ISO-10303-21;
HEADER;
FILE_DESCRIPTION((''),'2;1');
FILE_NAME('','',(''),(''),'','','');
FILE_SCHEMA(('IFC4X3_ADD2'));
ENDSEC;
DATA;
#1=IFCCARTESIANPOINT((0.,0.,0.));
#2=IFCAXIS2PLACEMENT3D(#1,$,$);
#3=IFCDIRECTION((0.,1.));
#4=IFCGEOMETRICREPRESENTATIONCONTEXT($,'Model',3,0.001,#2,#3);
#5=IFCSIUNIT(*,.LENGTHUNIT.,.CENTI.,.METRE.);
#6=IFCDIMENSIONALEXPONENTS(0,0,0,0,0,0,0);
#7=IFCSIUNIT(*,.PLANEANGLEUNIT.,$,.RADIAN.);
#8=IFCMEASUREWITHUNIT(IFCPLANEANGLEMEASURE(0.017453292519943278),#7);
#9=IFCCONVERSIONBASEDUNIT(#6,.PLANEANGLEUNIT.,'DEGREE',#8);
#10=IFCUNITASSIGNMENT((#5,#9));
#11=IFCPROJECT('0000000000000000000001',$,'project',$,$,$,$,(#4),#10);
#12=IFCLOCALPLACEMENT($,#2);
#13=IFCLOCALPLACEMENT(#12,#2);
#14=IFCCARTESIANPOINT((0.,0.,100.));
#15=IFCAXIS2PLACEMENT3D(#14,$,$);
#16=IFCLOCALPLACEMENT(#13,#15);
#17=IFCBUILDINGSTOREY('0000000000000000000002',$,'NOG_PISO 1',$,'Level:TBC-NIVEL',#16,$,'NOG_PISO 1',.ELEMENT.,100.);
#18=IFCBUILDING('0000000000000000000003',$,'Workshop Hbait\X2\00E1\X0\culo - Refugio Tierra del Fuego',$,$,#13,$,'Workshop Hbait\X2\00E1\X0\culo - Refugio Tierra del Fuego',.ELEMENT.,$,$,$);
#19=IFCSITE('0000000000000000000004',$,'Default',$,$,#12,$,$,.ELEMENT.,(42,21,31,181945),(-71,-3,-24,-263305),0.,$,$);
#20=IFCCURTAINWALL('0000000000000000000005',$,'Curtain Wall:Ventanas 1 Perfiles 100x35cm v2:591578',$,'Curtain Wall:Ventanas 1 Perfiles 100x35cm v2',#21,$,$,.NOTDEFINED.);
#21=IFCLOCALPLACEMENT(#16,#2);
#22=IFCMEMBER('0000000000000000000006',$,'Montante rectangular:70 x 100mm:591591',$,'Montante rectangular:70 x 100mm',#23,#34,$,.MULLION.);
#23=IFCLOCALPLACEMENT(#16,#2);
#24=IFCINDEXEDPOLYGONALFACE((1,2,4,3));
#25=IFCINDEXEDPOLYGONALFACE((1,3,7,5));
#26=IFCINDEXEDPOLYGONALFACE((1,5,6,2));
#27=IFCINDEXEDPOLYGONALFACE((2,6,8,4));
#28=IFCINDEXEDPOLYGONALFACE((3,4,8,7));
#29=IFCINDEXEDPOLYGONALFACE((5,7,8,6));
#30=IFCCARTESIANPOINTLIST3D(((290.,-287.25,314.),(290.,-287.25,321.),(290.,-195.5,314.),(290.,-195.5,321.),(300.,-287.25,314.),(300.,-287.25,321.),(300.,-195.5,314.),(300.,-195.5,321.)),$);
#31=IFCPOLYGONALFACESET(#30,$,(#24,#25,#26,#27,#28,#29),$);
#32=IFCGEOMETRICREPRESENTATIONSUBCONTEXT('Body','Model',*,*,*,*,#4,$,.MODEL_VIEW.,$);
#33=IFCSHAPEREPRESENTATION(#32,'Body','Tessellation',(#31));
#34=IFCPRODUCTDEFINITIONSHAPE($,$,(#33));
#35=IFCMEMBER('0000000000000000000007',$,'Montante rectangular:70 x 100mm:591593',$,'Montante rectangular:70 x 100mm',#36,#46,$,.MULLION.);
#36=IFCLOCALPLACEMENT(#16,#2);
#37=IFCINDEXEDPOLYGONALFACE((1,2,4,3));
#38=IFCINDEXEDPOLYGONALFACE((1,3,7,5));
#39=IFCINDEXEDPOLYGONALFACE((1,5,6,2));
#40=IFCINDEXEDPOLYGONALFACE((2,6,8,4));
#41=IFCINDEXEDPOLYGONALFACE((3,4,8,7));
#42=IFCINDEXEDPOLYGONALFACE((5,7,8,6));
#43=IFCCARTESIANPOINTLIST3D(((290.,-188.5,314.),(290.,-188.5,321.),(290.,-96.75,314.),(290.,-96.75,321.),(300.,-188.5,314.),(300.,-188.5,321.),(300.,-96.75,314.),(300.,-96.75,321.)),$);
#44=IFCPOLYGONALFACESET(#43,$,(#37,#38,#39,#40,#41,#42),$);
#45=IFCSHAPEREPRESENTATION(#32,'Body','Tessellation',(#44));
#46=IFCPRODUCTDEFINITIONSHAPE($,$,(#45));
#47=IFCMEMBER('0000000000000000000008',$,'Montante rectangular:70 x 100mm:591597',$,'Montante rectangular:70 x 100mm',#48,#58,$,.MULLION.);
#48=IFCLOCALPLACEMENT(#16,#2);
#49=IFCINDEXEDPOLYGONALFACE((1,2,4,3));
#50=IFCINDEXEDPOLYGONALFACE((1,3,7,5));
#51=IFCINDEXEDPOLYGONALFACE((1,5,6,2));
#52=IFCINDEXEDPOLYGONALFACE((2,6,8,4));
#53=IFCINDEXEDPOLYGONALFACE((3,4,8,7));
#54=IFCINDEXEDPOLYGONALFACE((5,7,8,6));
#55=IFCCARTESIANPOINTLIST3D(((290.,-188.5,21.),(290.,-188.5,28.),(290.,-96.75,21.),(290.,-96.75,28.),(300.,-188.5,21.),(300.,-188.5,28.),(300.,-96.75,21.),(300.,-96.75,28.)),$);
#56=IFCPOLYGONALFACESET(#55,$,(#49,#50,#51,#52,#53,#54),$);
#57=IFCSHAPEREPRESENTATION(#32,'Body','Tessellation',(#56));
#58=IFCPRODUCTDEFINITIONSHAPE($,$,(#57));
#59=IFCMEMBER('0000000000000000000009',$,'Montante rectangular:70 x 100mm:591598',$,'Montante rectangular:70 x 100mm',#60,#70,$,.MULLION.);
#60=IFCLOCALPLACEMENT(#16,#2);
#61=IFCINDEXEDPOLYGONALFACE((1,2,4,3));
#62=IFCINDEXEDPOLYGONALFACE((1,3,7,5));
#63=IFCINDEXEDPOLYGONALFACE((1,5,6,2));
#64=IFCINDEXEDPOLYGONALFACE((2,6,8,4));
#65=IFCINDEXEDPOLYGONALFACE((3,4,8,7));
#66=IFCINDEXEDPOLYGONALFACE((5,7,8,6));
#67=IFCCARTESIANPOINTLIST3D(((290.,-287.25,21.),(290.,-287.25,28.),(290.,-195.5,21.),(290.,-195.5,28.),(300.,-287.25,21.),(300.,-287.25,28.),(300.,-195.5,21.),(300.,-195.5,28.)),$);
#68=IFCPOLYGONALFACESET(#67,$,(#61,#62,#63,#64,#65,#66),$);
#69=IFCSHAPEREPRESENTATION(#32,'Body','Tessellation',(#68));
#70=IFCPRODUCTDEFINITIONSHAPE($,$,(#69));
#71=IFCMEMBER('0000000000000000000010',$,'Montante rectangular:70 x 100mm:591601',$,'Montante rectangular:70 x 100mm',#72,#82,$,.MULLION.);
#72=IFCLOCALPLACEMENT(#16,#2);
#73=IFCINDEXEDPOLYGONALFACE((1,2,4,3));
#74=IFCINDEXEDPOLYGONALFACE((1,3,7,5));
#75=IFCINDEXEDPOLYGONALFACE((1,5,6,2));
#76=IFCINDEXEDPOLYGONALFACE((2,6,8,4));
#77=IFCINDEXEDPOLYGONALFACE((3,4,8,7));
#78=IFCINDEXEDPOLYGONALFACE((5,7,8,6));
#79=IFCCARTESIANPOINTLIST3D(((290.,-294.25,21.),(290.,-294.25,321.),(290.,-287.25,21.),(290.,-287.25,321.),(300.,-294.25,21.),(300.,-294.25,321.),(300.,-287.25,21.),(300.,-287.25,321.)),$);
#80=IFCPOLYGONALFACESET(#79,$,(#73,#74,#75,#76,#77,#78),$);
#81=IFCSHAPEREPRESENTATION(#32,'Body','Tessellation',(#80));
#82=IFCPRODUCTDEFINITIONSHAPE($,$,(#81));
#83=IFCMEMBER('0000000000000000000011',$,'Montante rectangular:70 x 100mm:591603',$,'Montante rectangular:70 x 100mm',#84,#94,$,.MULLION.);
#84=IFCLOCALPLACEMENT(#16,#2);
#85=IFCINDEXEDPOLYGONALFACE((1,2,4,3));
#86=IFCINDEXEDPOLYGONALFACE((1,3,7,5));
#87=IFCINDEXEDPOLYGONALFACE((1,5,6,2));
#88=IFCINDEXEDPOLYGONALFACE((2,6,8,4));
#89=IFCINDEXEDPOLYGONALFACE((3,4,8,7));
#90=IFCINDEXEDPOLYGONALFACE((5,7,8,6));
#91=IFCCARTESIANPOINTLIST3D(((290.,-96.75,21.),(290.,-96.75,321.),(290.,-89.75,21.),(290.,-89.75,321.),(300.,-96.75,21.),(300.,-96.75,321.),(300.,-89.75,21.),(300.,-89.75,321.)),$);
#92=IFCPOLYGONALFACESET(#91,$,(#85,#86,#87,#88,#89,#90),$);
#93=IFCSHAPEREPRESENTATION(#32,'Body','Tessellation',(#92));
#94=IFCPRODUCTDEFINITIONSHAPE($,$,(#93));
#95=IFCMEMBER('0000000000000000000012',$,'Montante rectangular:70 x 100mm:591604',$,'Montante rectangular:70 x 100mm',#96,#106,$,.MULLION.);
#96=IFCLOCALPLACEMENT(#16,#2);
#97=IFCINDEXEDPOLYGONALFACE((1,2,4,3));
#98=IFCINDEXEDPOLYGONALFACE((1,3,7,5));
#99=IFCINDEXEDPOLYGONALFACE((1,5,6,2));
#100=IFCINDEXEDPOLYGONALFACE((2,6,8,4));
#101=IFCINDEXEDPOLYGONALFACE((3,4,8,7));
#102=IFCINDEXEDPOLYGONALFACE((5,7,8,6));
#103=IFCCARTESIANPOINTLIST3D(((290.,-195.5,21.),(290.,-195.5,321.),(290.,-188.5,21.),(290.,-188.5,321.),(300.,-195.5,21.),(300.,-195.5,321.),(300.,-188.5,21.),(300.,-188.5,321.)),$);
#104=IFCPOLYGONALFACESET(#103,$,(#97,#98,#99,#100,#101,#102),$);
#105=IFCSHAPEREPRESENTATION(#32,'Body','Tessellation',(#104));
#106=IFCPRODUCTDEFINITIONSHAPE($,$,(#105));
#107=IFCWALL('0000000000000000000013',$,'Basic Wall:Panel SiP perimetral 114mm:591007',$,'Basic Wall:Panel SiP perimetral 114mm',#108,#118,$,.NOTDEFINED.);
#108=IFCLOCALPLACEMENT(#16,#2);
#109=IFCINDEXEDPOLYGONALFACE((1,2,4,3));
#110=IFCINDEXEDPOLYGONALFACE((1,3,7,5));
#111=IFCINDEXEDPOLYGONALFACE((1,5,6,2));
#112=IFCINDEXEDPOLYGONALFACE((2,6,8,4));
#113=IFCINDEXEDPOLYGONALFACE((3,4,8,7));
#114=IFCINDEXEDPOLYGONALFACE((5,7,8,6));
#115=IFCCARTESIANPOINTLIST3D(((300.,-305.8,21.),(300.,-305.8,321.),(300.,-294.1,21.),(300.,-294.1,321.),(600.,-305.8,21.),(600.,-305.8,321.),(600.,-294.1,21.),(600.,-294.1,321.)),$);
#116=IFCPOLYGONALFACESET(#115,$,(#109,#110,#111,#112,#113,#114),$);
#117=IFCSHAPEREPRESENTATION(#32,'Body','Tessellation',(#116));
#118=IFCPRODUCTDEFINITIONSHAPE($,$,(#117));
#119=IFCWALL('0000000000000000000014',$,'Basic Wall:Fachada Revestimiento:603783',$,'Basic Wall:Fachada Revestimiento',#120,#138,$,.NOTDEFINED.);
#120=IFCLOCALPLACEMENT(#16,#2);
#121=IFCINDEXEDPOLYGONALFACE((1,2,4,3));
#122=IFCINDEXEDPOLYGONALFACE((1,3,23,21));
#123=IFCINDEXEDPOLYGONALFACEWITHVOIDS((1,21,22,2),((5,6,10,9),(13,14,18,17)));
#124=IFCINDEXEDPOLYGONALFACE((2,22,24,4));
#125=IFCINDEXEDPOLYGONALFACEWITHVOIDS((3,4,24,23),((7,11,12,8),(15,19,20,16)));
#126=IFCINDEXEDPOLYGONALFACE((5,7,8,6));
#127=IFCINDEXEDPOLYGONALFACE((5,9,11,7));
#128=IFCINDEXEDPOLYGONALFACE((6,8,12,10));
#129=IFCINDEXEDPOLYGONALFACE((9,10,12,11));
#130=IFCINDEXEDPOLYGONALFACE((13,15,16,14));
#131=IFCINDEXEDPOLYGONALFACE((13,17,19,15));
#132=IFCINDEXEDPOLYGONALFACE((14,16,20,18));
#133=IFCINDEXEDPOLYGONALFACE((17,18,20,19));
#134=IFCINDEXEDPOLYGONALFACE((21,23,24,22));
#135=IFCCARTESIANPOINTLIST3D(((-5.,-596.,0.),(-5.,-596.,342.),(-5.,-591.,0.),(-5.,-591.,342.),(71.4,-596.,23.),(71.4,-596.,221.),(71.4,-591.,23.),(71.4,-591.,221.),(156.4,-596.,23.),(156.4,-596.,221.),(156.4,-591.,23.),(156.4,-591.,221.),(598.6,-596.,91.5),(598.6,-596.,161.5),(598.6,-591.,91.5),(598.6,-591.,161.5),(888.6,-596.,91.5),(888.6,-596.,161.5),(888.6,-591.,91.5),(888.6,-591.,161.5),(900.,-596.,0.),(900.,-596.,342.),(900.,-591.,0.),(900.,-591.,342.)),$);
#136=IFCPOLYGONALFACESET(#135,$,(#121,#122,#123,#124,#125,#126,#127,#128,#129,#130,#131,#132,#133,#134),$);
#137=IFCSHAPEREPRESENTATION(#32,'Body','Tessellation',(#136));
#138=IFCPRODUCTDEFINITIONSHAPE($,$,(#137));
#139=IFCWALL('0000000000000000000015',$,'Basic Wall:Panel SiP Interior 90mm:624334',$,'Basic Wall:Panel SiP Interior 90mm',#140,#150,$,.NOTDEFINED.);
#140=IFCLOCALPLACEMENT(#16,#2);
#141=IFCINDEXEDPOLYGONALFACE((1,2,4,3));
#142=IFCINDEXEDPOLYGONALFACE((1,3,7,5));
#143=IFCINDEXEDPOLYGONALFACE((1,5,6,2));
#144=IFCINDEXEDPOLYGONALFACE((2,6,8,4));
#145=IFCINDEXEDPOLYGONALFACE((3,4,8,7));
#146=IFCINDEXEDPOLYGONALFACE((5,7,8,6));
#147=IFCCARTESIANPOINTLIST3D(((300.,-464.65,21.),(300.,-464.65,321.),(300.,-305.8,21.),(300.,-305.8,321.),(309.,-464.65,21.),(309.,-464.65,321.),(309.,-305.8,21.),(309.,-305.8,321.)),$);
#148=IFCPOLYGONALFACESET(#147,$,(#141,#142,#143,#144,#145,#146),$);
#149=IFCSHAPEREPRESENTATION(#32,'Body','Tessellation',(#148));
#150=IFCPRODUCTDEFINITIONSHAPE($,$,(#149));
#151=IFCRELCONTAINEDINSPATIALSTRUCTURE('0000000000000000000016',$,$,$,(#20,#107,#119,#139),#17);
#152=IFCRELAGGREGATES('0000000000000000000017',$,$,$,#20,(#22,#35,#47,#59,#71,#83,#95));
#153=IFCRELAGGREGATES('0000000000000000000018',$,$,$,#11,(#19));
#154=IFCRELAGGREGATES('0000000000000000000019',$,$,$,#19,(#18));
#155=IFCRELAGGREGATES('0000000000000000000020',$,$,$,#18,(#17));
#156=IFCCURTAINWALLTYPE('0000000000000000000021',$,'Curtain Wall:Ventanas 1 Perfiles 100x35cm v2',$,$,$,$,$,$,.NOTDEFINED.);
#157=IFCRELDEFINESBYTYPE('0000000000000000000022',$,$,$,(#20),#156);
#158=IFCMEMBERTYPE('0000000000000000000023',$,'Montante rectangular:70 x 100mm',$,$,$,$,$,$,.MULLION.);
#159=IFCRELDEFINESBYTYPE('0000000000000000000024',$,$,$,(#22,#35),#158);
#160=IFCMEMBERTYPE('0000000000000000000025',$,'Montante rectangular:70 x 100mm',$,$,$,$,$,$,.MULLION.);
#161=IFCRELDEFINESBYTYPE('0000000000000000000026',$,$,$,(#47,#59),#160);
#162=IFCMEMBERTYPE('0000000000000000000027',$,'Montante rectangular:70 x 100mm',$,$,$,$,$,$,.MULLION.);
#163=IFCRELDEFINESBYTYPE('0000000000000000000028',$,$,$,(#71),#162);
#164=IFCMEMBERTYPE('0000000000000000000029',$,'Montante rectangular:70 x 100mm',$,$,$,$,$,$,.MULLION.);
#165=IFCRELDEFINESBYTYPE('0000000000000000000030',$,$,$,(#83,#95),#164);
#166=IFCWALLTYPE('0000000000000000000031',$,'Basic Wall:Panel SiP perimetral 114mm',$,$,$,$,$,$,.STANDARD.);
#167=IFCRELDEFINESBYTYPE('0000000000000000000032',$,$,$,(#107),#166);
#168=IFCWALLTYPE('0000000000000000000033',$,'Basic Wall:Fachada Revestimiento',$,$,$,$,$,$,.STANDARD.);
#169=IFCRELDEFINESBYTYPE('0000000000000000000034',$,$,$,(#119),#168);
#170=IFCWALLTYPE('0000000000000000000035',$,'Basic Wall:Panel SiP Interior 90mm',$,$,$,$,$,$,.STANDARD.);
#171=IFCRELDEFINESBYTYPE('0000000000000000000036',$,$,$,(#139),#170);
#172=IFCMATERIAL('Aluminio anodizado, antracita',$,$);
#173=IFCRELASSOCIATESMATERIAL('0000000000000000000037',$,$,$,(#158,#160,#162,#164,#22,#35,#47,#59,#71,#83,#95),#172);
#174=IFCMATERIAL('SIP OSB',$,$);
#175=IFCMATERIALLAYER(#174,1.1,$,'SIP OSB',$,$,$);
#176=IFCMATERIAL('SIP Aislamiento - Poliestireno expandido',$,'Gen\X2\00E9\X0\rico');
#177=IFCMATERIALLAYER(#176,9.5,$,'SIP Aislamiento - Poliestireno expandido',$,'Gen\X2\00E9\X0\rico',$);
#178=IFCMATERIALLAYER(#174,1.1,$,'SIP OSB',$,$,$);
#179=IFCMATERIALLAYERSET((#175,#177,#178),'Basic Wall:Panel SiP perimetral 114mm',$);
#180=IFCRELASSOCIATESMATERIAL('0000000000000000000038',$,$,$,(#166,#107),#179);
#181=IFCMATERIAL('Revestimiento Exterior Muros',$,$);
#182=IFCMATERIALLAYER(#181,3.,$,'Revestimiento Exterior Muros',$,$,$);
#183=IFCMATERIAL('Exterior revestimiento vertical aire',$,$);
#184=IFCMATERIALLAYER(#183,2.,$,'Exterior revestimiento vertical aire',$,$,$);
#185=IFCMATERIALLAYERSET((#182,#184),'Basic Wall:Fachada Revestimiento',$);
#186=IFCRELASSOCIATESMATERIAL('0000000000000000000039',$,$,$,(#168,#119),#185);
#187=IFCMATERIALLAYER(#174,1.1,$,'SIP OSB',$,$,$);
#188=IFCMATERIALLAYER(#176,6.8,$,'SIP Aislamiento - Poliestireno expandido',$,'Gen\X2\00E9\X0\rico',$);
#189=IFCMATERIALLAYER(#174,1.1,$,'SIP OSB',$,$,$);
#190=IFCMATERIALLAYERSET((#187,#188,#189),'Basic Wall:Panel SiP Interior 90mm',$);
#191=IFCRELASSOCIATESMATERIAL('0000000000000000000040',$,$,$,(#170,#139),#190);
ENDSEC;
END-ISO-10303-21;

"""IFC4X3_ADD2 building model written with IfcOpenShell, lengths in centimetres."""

from ifc_helpers import new_model, entity, si_unit, converted_unit, direction, frame, frame_2d, origin, origin_2d_with_axis, place, context, subcontext, project, spatial, rectangle, extrude, source, transform, mapped, material, layer, layer_set, material_profile, profile_set, profile_usage, type_object, type_shapes, element, aggregate, save


model = new_model("IFC4X3_ADD2")

# Units and contexts
model_context = context("Model", 3, precision=0.001, world=origin(), true_north=direction((0.0, 1.0)))
body_context = subcontext(model_context, "Body", "Model", "MODEL_VIEW")
ifc_project = project(units=[si_unit("LENGTHUNIT", "METRE", prefix="CENTI"), converted_unit("PLANEANGLEUNIT", "DEGREE", entity("IfcPlaneAngleMeasure", 0.017453292519943278), si_unit("PLANEANGLEUNIT", "RADIAN"), dimensions=[0, 0, 0, 0, 0, 0, 0])], contexts=[model_context])

# Site, building, storey
site_placement = place(None, origin())
site = spatial("IfcSite", under=ifc_project, at=site_placement, Name="Default", CompositionType="ELEMENT", RefLatitude=(42, 21, 31, 181945), RefLongitude=(-71, -3, -24, -263305), RefElevation=0.0)
building_placement = place(site_placement, origin())
building = spatial("IfcBuilding", under=site, at=building_placement, Name="Workshop Hbaitáculo - Refugio Tierra del Fuego", LongName="Workshop Hbaitáculo - Refugio Tierra del Fuego", CompositionType="ELEMENT")
storey_placement = place(building_placement, frame((0.0, 0.0, 100.0)))
storey = spatial("IfcBuildingStorey", under=building, at=storey_placement, Name="NOG_PISO 1", ObjectType="Level:TBC-NIVEL", LongName="NOG_PISO 1", CompositionType="ELEMENT", Elevation=100.0)

# Curtain wall, members
curtain_wall_type = type_object("IfcCurtainWallType", Name="Curtain Wall:Ventanas 1 Perfiles 100x35cm v2", PredefinedType="NOTDEFINED")
curtain_wall_placement = place(storey_placement, frame((0.0, 0.0, -100.0)))
curtain_wall = element("IfcCurtainWall", 1, at=curtain_wall_placement, inside=storey, type_object=curtain_wall_type, Name="Curtain Wall:Ventanas 1 Perfiles 100x35cm v2:591578", ObjectType="Curtain Wall:Ventanas 1 Perfiles 100x35cm v2", PredefinedType="NOTDEFINED")
ifc_material_1 = material(Name="Aluminio anodizado, antracita")
ifc_material_profile_1 = material_profile(ifc_material_1, rectangle(XDim=7.0, YDim=10.0, at=origin_2d_with_axis()), Name="70 x 100mm")
ifc_profile_set_1 = profile_set([ifc_material_profile_1], Name="70 x 100mm")
ifc_profile_usage_1 = profile_usage(ifc_profile_set_1)
member_type_1 = type_object("IfcMemberType", Name="Montante rectangular:70 x 100mm", PredefinedType="MULLION", material=ifc_profile_set_1)
shared_shape_1 = source(origin(), body_context, "Body", "SweptSolid", [
    extrude(rectangle(XDim=7.0, YDim=10.0, at=origin_2d_with_axis()), frame((-3.5, 0.0, -91.75), z_axis=(0.0, 0.0, 1.0), x_axis=(-1.0, 0.0, 0.0)), (0.0, 0.0, 1.0), 91.75),
])
type_shapes(member_type_1, [shared_shape_1])
member_1_placement = place(curtain_wall_placement, frame((295.0, -287.25, 421.0), z_axis=(0.0, -1.0, 0.0), x_axis=(0.0, 0.0, 1.0)))
member_1 = element("IfcMember", 2, at=member_1_placement, type_object=member_type_1, material=ifc_profile_usage_1, Name="Montante rectangular:70 x 100mm:591591", ObjectType="Montante rectangular:70 x 100mm", PredefinedType="MULLION", context=body_context, shape_type="MappedRepresentation", body=[
    mapped(shared_shape_1, transform((0.0, 0.0, 0.0), scale=1.0)),
])
member_2_placement = place(curtain_wall_placement, frame((295.0, -188.5, 421.0), z_axis=(0.0, -1.0, 0.0), x_axis=(0.0, 0.0, 1.0)))
member_2 = element("IfcMember", 3, at=member_2_placement, type_object=member_type_1, material=ifc_profile_usage_1, Name="Montante rectangular:70 x 100mm:591593", ObjectType="Montante rectangular:70 x 100mm", PredefinedType="MULLION", context=body_context, shape_type="MappedRepresentation", body=[
    mapped(shared_shape_1, transform((0.0, 0.0, 0.0), scale=1.0)),
])
member_type_2 = type_object("IfcMemberType", Name="Montante rectangular:70 x 100mm", PredefinedType="MULLION", material=ifc_profile_set_1)
shared_shape_2 = source(origin(), body_context, "Body", "SweptSolid", [
    extrude(rectangle(XDim=7.0, YDim=10.0, at=origin_2d_with_axis()), frame((-3.5, 0.0, -91.75), z_axis=(0.0, 0.0, 1.0), x_axis=(-1.0, 0.0, 0.0)), (0.0, 0.0, 1.0), 91.75),
])
type_shapes(member_type_2, [shared_shape_2])
member_3_placement = place(curtain_wall_placement, frame((295.0, -96.75, 121.0), z_axis=(0.0, 1.0, 0.0), x_axis=(0.0, 0.0, -1.0)))
member_3 = element("IfcMember", 4, at=member_3_placement, type_object=member_type_2, material=ifc_profile_usage_1, Name="Montante rectangular:70 x 100mm:591597", ObjectType="Montante rectangular:70 x 100mm", PredefinedType="MULLION", context=body_context, shape_type="MappedRepresentation", body=[
    mapped(shared_shape_2, transform((0.0, 0.0, 0.0), scale=1.0)),
])
member_4_placement = place(curtain_wall_placement, frame((295.0, -195.5, 121.0), z_axis=(0.0, 1.0, 0.0), x_axis=(0.0, 0.0, -1.0)))
member_4 = element("IfcMember", 5, at=member_4_placement, type_object=member_type_2, material=ifc_profile_usage_1, Name="Montante rectangular:70 x 100mm:591598", ObjectType="Montante rectangular:70 x 100mm", PredefinedType="MULLION", context=body_context, shape_type="MappedRepresentation", body=[
    mapped(shared_shape_2, transform((0.0, 0.0, 0.0), scale=1.0)),
])
member_type_3 = type_object("IfcMemberType", Name="Montante rectangular:70 x 100mm", PredefinedType="MULLION", material=ifc_profile_set_1)
shared_shape_3 = source(origin(), body_context, "Body", "SweptSolid", [
    extrude(rectangle(XDim=7.0, YDim=10.0, at=origin_2d_with_axis()), frame((-3.5, 0.0, -300.0), z_axis=(0.0, 0.0, 1.0), x_axis=(-1.0, 0.0, 0.0)), (0.0, 0.0, 1.0), 300.0),
])
type_shapes(member_type_3, [shared_shape_3])
member_5_placement = place(curtain_wall_placement, frame((295.0, -294.25, 121.0), z_axis=(0.0, 0.0, -1.0), x_axis=(0.0, -1.0, 0.0)))
member_5 = element("IfcMember", 6, at=member_5_placement, type_object=member_type_3, material=ifc_profile_usage_1, Name="Montante rectangular:70 x 100mm:591601", ObjectType="Montante rectangular:70 x 100mm", PredefinedType="MULLION", context=body_context, shape_type="MappedRepresentation", body=[
    mapped(shared_shape_3, transform((0.0, 0.0, 0.0), scale=1.0)),
])
member_type_4 = type_object("IfcMemberType", Name="Montante rectangular:70 x 100mm", PredefinedType="MULLION", material=ifc_profile_set_1)
shared_shape_4 = source(origin(), body_context, "Body", "SweptSolid", [
    extrude(rectangle(XDim=7.0, YDim=10.0, at=frame_2d((0.0, 0.0), x_axis=(1.0, 0.0))), frame((0.0, 0.0, -300.0), z_axis=(0.0, 0.0, 1.0), x_axis=(-1.0, 0.0, 0.0)), (0.0, 0.0, 1.0), 300.0),
])
type_shapes(member_type_4, [shared_shape_4])
member_6_placement = place(curtain_wall_placement, frame((295.0, -93.25, 121.0), z_axis=(0.0, 0.0, -1.0), x_axis=(0.0, -1.0, 0.0)))
member_6 = element("IfcMember", 7, at=member_6_placement, type_object=member_type_4, material=ifc_profile_usage_1, Name="Montante rectangular:70 x 100mm:591603", ObjectType="Montante rectangular:70 x 100mm", PredefinedType="MULLION", context=body_context, shape_type="MappedRepresentation", body=[
    mapped(shared_shape_4, transform((0.0, 0.0, 0.0), scale=1.0)),
])
member_7_placement = place(curtain_wall_placement, frame((295.0, -192.0, 121.0), z_axis=(0.0, 0.0, -1.0), x_axis=(0.0, -1.0, 0.0)))
member_7 = element("IfcMember", 8, at=member_7_placement, type_object=member_type_4, material=ifc_profile_usage_1, Name="Montante rectangular:70 x 100mm:591604", ObjectType="Montante rectangular:70 x 100mm", PredefinedType="MULLION", context=body_context, shape_type="MappedRepresentation", body=[
    mapped(shared_shape_4, transform((0.0, 0.0, 0.0), scale=1.0)),
])

aggregate(curtain_wall, [member_1, member_2, member_3, member_4, member_5, member_6, member_7])

# Wall
ifc_material_2 = material(Name="SIP OSB")
ifc_layer_1 = layer(ifc_material_2, 1.1, Name="SIP OSB")
ifc_material_3 = material(Name="SIP Aislamiento - Poliestireno expandido", Category="Genérico")
ifc_layer_2 = layer(ifc_material_3, 9.5, Name="SIP Aislamiento - Poliestireno expandido", Category="Genérico")
ifc_layer_3 = layer(ifc_material_2, 1.1, Name="SIP OSB")
ifc_layer_set_1 = layer_set([ifc_layer_1, ifc_layer_2, ifc_layer_3], Name="Basic Wall:Panel SiP perimetral 114mm")
wall_type_1 = type_object("IfcWallType", Name="Basic Wall:Panel SiP perimetral 114mm", PredefinedType="STANDARD", material=ifc_layer_set_1)
wall_1_placement = place(storey_placement, frame((300.0, -299.95, 21.0)))
element("IfcWall", 9, at=wall_1_placement, inside=storey, type_object=wall_type_1, material=ifc_layer_set_1, Name="Basic Wall:Panel SiP perimetral 114mm:591007", ObjectType="Basic Wall:Panel SiP perimetral 114mm", PredefinedType="NOTDEFINED", context=body_context, shape_type="SweptSolid", body=[
    extrude(rectangle(XDim=300.0, YDim=11.7, at=frame_2d((150.0, 0.0), x_axis=(-1.0, 0.0))), origin(), (0.0, 0.0, 1.0), 300.0),
])

# Wall, openings
ifc_material_4 = material(Name="Revestimiento Exterior Muros")
ifc_layer_4 = layer(ifc_material_4, 3.0, Name="Revestimiento Exterior Muros")
ifc_material_5 = material(Name="Exterior revestimiento vertical aire")
ifc_layer_5 = layer(ifc_material_5, 2.0, Name="Exterior revestimiento vertical aire")
ifc_layer_set_2 = layer_set([ifc_layer_4, ifc_layer_5], Name="Basic Wall:Fachada Revestimiento")
wall_type_2 = type_object("IfcWallType", Name="Basic Wall:Fachada Revestimiento", PredefinedType="STANDARD", material=ifc_layer_set_2)
wall_2_placement = place(storey_placement, frame((-5.0, -593.5, 0.0)))
wall_2 = element("IfcWall", 10, at=wall_2_placement, inside=storey, type_object=wall_type_2, material=ifc_layer_set_2, Name="Basic Wall:Fachada Revestimiento:603783", ObjectType="Basic Wall:Fachada Revestimiento", PredefinedType="NOTDEFINED", context=body_context, shape_type="SweptSolid", body=[
    extrude(rectangle(XDim=905.0, YDim=5.0, at=frame_2d((452.5, 0.0), x_axis=(-1.0, 0.0))), origin(), (0.0, 0.0, 1.0), 342.0),
])
opening_1_placement = place(wall_2_placement, origin())
element("IfcOpeningElement", 11, at=opening_1_placement, cuts=wall_2, PredefinedType="OPENING", context=body_context, shape_type="SweptSolid", body=[
    extrude(rectangle(XDim=198.0, YDim=85.0, at=frame_2d((0.0, 0.0), x_axis=(1.0, 0.0))), frame((118.9, 2.5, 122.0), z_axis=(0.0, -1.0, 0.0), x_axis=(0.0, 0.0, 1.0)), (0.0, 0.0, 1.0), 5.0),
])
opening_2_placement = place(wall_2_placement, origin())
element("IfcOpeningElement", 12, at=opening_2_placement, cuts=wall_2, PredefinedType="OPENING", context=body_context, shape_type="SweptSolid", body=[
    extrude(rectangle(XDim=70.0, YDim=290.0, at=frame_2d((0.0, 0.0), x_axis=(1.0, 0.0))), frame((748.6, 2.5, 126.5), z_axis=(0.0, -1.0, 0.0), x_axis=(0.0, 0.0, -1.0)), (0.0, 0.0, 1.0), 5.0),
])

# Wall
ifc_layer_6 = layer(ifc_material_2, 1.1, Name="SIP OSB")
ifc_layer_7 = layer(ifc_material_3, 6.8, Name="SIP Aislamiento - Poliestireno expandido", Category="Genérico")
ifc_layer_8 = layer(ifc_material_2, 1.1, Name="SIP OSB")
ifc_layer_set_3 = layer_set([ifc_layer_6, ifc_layer_7, ifc_layer_8], Name="Basic Wall:Panel SiP Interior 90mm")
wall_type_3 = type_object("IfcWallType", Name="Basic Wall:Panel SiP Interior 90mm", PredefinedType="STANDARD", material=ifc_layer_set_3)
wall_3_placement = place(storey_placement, frame((304.5, -305.8, 21.0), z_axis=(0.0, 0.0, 1.0), x_axis=(0.0, -1.0, 0.0)))
element("IfcWall", 13, at=wall_3_placement, inside=storey, type_object=wall_type_3, material=ifc_layer_set_3, Name="Basic Wall:Panel SiP Interior 90mm:624334", ObjectType="Basic Wall:Panel SiP Interior 90mm", PredefinedType="NOTDEFINED", context=body_context, shape_type="SweptSolid", body=[
    extrude(rectangle(XDim=158.85, YDim=9.0, at=frame_2d((79.42, 0.0), x_axis=(-1.0, 0.0))), origin(), (0.0, 0.0, 1.0), 300.0),
])

save(model, "model.ifc")
